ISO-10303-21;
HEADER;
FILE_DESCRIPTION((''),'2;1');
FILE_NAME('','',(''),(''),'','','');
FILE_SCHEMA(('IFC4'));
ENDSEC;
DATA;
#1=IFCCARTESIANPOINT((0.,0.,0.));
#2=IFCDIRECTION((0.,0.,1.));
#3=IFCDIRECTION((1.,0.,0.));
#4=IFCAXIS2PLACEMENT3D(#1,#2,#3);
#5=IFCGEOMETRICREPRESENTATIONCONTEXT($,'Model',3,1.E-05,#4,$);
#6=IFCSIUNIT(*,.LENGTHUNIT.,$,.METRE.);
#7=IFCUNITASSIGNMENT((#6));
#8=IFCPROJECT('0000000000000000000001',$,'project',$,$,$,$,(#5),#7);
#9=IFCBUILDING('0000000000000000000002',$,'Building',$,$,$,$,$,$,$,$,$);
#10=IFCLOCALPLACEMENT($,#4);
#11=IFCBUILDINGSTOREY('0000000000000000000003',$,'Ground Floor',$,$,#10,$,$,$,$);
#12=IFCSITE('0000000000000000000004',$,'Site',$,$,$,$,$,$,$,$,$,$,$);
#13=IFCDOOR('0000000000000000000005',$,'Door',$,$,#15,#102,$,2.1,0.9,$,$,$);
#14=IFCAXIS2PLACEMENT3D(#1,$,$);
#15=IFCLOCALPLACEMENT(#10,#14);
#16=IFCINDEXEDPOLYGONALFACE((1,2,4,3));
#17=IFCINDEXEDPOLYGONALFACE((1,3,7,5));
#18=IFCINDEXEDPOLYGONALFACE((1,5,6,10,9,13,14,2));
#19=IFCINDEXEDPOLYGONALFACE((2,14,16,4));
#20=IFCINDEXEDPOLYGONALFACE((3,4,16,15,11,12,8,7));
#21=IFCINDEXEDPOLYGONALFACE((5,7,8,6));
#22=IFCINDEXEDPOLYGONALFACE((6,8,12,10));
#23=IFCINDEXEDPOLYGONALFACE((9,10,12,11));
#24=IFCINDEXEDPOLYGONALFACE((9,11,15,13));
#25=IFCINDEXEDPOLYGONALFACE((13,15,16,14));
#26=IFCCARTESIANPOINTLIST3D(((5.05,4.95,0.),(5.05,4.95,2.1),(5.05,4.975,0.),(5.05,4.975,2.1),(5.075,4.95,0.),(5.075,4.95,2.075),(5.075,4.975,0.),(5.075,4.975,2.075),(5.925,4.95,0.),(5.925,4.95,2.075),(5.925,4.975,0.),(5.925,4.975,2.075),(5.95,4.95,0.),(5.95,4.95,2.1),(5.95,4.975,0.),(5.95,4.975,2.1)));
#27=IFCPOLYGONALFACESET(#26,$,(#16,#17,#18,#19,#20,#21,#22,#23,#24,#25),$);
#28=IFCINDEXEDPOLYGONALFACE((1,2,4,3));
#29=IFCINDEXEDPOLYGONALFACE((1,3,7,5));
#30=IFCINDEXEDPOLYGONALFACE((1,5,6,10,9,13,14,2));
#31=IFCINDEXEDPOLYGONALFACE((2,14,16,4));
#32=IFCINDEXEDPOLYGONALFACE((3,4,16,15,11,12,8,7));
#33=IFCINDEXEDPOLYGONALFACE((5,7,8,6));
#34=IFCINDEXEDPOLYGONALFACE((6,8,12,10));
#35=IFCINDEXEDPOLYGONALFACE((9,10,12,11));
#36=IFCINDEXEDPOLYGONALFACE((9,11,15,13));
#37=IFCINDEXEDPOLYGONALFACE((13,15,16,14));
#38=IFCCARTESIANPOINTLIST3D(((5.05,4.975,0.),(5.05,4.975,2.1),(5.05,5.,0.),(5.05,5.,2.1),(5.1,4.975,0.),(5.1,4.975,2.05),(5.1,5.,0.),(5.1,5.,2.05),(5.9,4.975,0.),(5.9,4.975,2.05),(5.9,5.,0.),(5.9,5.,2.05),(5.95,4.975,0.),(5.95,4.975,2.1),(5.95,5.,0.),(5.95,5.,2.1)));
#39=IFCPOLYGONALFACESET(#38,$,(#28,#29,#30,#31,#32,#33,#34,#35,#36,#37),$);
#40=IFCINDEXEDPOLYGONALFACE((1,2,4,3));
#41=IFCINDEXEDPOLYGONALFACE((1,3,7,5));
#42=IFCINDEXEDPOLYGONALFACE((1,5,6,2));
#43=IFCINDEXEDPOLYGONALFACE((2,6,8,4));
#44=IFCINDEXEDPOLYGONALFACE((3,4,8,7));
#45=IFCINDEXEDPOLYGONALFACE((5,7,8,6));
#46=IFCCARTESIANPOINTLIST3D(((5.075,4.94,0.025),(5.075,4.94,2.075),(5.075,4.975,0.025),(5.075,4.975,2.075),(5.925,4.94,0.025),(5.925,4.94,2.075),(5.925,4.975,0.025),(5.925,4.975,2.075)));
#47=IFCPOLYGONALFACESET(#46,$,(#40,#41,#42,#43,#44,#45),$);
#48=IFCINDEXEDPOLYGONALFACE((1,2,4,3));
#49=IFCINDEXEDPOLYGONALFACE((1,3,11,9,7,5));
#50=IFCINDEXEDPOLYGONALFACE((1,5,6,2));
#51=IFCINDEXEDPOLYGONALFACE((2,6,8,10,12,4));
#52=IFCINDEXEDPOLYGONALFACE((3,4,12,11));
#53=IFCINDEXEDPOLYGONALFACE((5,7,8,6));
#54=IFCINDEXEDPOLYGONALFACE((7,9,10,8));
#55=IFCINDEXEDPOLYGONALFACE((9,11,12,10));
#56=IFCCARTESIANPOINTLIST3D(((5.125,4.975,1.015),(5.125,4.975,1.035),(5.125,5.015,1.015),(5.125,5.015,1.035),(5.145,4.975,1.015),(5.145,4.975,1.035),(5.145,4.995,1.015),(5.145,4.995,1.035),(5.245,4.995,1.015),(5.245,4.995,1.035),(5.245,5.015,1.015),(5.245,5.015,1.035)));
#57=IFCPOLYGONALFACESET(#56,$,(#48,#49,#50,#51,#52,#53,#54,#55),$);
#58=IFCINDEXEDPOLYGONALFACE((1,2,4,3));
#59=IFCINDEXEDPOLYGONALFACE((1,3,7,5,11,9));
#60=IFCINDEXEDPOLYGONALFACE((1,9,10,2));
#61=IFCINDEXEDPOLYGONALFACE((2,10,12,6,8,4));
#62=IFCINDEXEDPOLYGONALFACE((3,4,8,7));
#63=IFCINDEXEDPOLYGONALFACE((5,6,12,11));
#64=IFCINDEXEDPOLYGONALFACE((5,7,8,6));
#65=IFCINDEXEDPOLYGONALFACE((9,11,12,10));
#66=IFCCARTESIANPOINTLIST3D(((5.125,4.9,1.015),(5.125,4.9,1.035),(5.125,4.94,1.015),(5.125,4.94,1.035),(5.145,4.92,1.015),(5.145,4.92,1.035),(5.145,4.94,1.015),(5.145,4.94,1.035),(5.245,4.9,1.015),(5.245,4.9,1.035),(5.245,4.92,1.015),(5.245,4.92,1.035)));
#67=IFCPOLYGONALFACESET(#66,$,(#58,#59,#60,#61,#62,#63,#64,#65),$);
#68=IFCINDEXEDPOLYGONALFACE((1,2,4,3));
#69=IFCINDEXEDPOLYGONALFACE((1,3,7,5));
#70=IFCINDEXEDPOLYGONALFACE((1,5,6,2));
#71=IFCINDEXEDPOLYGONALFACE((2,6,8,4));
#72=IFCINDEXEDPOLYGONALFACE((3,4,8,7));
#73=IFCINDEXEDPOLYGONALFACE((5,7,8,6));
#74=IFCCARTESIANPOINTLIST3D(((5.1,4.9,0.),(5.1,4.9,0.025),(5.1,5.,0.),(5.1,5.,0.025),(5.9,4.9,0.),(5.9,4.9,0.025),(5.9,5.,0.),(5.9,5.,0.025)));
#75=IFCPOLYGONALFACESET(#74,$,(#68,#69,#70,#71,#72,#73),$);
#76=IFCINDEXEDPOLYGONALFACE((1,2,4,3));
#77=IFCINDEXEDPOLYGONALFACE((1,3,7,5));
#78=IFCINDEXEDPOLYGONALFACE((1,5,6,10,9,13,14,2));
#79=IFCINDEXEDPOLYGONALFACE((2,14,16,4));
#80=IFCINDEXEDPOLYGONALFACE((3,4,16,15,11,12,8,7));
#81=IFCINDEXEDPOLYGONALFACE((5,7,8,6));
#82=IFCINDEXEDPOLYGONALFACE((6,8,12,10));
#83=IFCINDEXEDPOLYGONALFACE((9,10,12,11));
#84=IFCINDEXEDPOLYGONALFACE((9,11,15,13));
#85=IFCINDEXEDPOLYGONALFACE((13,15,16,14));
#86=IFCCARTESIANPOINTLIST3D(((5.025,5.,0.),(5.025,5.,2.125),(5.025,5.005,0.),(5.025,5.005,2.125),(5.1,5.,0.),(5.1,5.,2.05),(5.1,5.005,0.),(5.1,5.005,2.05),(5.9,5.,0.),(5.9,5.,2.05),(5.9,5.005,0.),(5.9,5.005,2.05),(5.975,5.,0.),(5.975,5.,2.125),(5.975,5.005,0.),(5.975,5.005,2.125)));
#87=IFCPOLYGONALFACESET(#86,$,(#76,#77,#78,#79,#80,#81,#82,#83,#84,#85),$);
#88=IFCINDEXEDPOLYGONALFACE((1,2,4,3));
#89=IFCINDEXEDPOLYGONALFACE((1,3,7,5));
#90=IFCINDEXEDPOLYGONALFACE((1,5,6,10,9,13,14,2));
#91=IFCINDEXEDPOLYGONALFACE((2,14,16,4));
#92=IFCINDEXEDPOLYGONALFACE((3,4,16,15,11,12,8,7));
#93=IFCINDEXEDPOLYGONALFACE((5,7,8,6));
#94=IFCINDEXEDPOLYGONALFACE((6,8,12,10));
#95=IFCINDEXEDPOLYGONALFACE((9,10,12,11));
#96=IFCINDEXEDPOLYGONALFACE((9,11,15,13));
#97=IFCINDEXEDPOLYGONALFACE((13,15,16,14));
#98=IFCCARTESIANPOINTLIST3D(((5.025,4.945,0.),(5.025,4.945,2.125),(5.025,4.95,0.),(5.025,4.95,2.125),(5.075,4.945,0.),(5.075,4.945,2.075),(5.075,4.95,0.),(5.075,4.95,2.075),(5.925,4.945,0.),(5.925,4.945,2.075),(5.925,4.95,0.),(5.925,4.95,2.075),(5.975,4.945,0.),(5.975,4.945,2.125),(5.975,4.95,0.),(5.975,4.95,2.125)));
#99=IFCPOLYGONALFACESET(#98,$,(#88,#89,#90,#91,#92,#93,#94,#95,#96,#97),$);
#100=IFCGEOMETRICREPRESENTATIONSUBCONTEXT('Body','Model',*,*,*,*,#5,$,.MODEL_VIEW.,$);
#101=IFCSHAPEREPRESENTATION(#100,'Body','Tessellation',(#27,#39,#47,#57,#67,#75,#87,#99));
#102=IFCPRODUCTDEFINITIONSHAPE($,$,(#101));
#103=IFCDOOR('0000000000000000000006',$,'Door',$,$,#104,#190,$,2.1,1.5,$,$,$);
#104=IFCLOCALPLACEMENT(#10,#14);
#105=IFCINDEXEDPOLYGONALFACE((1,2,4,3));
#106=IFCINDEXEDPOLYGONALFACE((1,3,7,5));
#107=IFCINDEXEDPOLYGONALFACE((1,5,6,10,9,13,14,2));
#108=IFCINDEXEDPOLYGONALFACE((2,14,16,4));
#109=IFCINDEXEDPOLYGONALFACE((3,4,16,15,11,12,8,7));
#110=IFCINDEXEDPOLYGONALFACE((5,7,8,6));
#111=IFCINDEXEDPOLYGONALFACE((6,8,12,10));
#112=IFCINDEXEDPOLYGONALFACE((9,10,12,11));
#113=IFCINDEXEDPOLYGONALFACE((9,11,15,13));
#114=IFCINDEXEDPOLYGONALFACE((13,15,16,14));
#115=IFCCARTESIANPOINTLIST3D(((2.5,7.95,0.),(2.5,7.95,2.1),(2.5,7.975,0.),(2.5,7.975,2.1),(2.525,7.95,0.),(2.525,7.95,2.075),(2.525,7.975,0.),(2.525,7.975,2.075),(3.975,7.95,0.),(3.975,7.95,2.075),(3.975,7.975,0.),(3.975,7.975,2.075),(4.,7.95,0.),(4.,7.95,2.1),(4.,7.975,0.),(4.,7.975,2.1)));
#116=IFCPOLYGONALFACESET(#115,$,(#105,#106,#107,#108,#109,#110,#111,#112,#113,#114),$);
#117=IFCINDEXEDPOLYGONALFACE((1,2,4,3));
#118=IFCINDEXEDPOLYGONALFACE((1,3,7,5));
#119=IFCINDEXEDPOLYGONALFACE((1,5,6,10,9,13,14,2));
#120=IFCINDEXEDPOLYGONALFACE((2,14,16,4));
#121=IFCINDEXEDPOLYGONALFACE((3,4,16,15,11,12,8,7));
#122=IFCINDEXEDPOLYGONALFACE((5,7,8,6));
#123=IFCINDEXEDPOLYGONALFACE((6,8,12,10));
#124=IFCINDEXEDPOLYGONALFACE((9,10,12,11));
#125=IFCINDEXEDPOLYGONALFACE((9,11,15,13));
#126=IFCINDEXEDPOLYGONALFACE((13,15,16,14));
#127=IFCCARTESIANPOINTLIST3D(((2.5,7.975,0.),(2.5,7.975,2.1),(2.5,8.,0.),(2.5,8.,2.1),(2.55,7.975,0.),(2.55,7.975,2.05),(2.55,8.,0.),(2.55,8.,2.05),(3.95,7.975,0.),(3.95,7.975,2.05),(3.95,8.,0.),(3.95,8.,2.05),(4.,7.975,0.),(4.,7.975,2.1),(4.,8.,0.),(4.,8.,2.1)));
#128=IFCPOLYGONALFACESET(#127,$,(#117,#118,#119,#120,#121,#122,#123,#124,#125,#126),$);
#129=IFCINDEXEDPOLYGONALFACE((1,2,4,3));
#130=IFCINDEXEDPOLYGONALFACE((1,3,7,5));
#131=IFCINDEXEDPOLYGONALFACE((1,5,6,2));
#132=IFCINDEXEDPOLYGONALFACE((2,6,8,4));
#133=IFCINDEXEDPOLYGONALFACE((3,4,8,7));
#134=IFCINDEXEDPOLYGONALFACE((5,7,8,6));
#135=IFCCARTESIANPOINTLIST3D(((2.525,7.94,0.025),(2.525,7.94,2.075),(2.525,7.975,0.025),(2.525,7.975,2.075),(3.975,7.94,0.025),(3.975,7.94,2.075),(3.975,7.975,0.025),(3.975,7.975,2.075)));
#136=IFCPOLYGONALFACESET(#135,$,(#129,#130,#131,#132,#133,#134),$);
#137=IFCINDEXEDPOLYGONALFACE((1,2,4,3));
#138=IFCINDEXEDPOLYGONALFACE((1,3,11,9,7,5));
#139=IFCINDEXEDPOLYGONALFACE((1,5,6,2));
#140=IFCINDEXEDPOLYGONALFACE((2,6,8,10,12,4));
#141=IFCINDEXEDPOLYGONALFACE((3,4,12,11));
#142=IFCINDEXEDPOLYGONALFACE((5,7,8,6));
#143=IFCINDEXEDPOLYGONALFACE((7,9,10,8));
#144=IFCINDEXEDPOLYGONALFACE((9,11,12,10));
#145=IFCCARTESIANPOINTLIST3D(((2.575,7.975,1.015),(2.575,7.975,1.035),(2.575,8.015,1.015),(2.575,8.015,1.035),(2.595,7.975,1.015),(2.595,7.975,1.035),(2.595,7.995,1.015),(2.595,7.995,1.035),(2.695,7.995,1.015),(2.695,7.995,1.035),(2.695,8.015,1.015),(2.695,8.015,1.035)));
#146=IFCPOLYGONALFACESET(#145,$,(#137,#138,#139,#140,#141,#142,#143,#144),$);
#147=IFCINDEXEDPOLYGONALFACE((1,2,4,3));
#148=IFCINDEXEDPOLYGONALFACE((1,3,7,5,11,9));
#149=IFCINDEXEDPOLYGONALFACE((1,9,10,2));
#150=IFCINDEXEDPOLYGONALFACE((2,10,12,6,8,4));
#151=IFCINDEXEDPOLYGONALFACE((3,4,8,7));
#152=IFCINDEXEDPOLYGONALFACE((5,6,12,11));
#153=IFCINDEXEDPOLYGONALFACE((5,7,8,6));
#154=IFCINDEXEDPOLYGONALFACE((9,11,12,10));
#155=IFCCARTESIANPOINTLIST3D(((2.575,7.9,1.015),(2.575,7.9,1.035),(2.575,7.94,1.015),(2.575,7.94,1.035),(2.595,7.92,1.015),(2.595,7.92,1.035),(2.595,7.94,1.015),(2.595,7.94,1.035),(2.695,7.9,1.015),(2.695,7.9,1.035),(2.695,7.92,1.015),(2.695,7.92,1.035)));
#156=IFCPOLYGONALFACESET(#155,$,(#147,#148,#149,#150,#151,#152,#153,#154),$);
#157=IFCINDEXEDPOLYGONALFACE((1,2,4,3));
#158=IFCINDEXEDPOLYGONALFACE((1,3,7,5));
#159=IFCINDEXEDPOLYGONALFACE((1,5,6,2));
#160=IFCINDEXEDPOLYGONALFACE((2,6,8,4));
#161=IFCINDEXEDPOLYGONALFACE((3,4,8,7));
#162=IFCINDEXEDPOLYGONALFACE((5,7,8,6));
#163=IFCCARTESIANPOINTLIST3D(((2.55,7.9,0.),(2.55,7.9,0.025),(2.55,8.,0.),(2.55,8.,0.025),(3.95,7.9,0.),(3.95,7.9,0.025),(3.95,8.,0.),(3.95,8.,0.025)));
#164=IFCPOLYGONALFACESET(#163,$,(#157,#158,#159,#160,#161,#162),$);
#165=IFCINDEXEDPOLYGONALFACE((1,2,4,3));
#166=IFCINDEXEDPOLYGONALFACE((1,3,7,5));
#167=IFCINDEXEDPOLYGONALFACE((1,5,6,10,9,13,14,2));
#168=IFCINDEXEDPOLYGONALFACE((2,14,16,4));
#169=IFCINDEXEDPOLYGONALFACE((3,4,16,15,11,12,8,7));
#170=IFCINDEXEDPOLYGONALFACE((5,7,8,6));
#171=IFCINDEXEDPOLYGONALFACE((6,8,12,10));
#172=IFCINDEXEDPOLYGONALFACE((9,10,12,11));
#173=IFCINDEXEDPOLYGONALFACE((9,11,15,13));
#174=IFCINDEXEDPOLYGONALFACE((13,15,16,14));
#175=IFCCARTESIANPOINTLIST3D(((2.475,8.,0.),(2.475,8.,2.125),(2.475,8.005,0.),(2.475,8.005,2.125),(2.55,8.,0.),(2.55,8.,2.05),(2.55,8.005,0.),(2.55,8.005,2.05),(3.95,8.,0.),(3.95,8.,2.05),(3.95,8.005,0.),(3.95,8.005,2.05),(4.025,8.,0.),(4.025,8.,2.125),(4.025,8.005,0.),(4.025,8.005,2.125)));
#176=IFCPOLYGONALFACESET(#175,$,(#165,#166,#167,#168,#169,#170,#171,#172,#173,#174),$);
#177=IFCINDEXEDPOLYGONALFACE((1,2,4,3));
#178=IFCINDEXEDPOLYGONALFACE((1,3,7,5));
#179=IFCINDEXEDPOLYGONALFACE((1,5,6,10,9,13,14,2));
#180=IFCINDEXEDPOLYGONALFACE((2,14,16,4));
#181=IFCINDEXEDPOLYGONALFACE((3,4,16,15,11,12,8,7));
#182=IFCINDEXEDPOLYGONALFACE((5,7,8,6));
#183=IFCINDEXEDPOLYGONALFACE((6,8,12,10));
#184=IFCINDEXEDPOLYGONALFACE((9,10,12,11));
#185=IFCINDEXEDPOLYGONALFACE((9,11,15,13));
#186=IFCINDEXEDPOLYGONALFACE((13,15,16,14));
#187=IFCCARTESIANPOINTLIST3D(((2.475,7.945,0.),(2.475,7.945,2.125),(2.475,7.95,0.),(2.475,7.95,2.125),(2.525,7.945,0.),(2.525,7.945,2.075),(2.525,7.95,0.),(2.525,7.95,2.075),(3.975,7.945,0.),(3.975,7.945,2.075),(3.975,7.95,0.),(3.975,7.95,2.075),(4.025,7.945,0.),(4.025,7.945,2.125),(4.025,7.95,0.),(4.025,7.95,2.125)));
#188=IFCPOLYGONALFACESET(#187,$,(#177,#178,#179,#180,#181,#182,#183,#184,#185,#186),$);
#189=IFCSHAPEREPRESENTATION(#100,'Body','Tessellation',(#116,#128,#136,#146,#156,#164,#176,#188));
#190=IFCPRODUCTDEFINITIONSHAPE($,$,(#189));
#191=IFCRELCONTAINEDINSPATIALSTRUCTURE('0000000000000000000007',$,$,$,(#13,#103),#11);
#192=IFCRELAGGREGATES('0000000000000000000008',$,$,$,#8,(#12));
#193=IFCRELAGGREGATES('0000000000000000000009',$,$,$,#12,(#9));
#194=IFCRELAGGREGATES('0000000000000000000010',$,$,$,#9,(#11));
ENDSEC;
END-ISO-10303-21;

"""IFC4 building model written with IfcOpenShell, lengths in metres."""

from ifc_helpers import new_model, si_unit, frame, origin_with_axes, place, context, subcontext, project, spatial, line, indexed_curve, outline, extrude, element, save


model = new_model("IFC4")

# Units and contexts
model_context = context("Model", 3, precision=1e-05, world=origin_with_axes())
body_context = subcontext(model_context, "Body", "Model", "MODEL_VIEW")
ifc_project = project(units=[si_unit("LENGTHUNIT", "METRE")], contexts=[model_context])

# Site, building, storey
site = spatial("IfcSite", under=ifc_project, Name="Site")
building = spatial("IfcBuilding", under=site, Name="Building")
storey_placement = place(None, origin_with_axes())
storey = spatial("IfcBuildingStorey", under=building, at=storey_placement, Name="Ground Floor")

# Doors
door_1_placement = place(storey_placement, frame((5.95, 5.0, 0.0), z_axis=(0.0, 0.0, 1.0), x_axis=(-1.0, 0.0, 0.0)))
element("IfcDoor", 1, at=door_1_placement, inside=storey, Name="Door", OverallHeight=2.1, OverallWidth=0.9, context=body_context, shape_type="SweptSolid", body=[
    extrude(outline(indexed_curve([(0.0, 0.0), (0.0, 2.1), (0.9, 2.1), (0.9, 0.0), (0.875, 0.0), (0.875, 2.075), (0.025, 2.075), (0.025, 0.0)], segments=[line(1, 2, 3, 4, 5, 6, 7, 8, 1)])), frame((0.0, 0.025, 0.0), z_axis=(0.0, -1.0, 0.0), x_axis=(1.0, 0.0, 0.0)), (0.0, 0.0, -1.0), 0.025),
    extrude(outline(indexed_curve([(0.0, 0.0), (0.0, 2.1), (0.9, 2.1), (0.9, 0.0), (0.85, 0.0), (0.85, 2.05), (0.05, 2.05), (0.05, 0.0)], segments=[line(1, 2, 3, 4, 5, 6, 7, 8, 1)])), frame((0.0, 0.0, 0.0), z_axis=(0.0, -1.0, 0.0), x_axis=(1.0, 0.0, 0.0)), (0.0, 0.0, -1.0), 0.025),
    extrude(outline(indexed_curve([(0.0, 0.0), (0.85, 0.0), (0.85, 0.035), (0.0, 0.035)], segments=[line(1, 2, 3, 4, 1)])), frame((0.025, 0.025, 0.025), z_axis=(0.0, 0.0, 1.0), x_axis=(1.0, 0.0, 0.0)), (0.0, 0.0, 1.0), 2.05),
    extrude(outline(indexed_curve([(0.0, 0.0), (0.0, -0.04), (-0.12, -0.04), (-0.12, -0.02), (-0.02, -0.02), (-0.02, 0.0)], segments=[line(1, 2, 3, 4, 5, 6, 1)])), frame((0.825, 0.025, 1.015), z_axis=(0.0, 0.0, 1.0), x_axis=(1.0, 0.0, 0.0)), (0.0, 0.0, 1.0), 0.02),
    extrude(outline(indexed_curve([(0.0, 0.0), (0.0, 0.04), (-0.12, 0.04), (-0.12, 0.02), (-0.02, 0.02), (-0.02, 0.0)], segments=[line(1, 2, 3, 4, 5, 6, 1)])), frame((0.825, 0.06, 1.015), z_axis=(0.0, 0.0, 1.0), x_axis=(1.0, 0.0, 0.0)), (0.0, 0.0, 1.0), 0.02),
    extrude(outline(indexed_curve([(0.0, 0.0), (0.8, 0.0), (0.8, 0.1), (0.0, 0.1)], segments=[line(1, 2, 3, 4, 1)])), frame((0.05, 0.0, 0.0), z_axis=(0.0, 0.0, 1.0), x_axis=(1.0, 0.0, 0.0)), (0.0, 0.0, 1.0), 0.025),
    extrude(outline(indexed_curve([(0.0, 0.0), (0.0, 2.125), (0.95, 2.125), (0.95, 0.0), (0.875, 0.0), (0.875, 2.05), (0.075, 2.05), (0.075, 0.0)], segments=[line(1, 2, 3, 4, 5, 6, 7, 8, 1)])), frame((-0.025, -0.005, 0.0), z_axis=(0.0, -1.0, 0.0), x_axis=(1.0, 0.0, 0.0)), (0.0, 0.0, -1.0), 0.005),
    extrude(outline(indexed_curve([(0.0, 0.0), (0.0, 2.125), (0.95, 2.125), (0.95, 0.0), (0.9, 0.0), (0.9, 2.075), (0.05, 2.075), (0.05, 0.0)], segments=[line(1, 2, 3, 4, 5, 6, 7, 8, 1)])), frame((-0.025, 0.05, 0.0), z_axis=(0.0, -1.0, 0.0), x_axis=(1.0, 0.0, 0.0)), (0.0, 0.0, -1.0), 0.005),
])
door_2_placement = place(storey_placement, frame((4.0, 8.0, 0.0), z_axis=(0.0, 0.0, 1.0), x_axis=(-1.0, 0.0, 0.0)))
element("IfcDoor", 2, at=door_2_placement, inside=storey, Name="Door", OverallHeight=2.1, OverallWidth=1.5, context=body_context, shape_type="SweptSolid", body=[
    extrude(outline(indexed_curve([(0.0, 0.0), (0.0, 2.1), (1.5, 2.1), (1.5, 0.0), (1.475, 0.0), (1.475, 2.075), (0.025, 2.075), (0.025, 0.0)], segments=[line(1, 2, 3, 4, 5, 6, 7, 8, 1)])), frame((0.0, 0.025, 0.0), z_axis=(0.0, -1.0, 0.0), x_axis=(1.0, 0.0, 0.0)), (0.0, 0.0, -1.0), 0.025),
    extrude(outline(indexed_curve([(0.0, 0.0), (0.0, 2.1), (1.5, 2.1), (1.5, 0.0), (1.45, 0.0), (1.45, 2.05), (0.05, 2.05), (0.05, 0.0)], segments=[line(1, 2, 3, 4, 5, 6, 7, 8, 1)])), frame((0.0, 0.0, 0.0), z_axis=(0.0, -1.0, 0.0), x_axis=(1.0, 0.0, 0.0)), (0.0, 0.0, -1.0), 0.025),
    extrude(outline(indexed_curve([(0.0, 0.0), (1.45, 0.0), (1.45, 0.035), (0.0, 0.035)], segments=[line(1, 2, 3, 4, 1)])), frame((0.025, 0.025, 0.025), z_axis=(0.0, 0.0, 1.0), x_axis=(1.0, 0.0, 0.0)), (0.0, 0.0, 1.0), 2.05),
    extrude(outline(indexed_curve([(0.0, 0.0), (0.0, -0.04), (-0.12, -0.04), (-0.12, -0.02), (-0.02, -0.02), (-0.02, 0.0)], segments=[line(1, 2, 3, 4, 5, 6, 1)])), frame((1.425, 0.025, 1.015), z_axis=(0.0, 0.0, 1.0), x_axis=(1.0, 0.0, 0.0)), (0.0, 0.0, 1.0), 0.02),
    extrude(outline(indexed_curve([(0.0, 0.0), (0.0, 0.04), (-0.12, 0.04), (-0.12, 0.02), (-0.02, 0.02), (-0.02, 0.0)], segments=[line(1, 2, 3, 4, 5, 6, 1)])), frame((1.425, 0.06, 1.015), z_axis=(0.0, 0.0, 1.0), x_axis=(1.0, 0.0, 0.0)), (0.0, 0.0, 1.0), 0.02),
    extrude(outline(indexed_curve([(0.0, 0.0), (1.4, 0.0), (1.4, 0.1), (0.0, 0.1)], segments=[line(1, 2, 3, 4, 1)])), frame((0.05, 0.0, 0.0), z_axis=(0.0, 0.0, 1.0), x_axis=(1.0, 0.0, 0.0)), (0.0, 0.0, 1.0), 0.025),
    extrude(outline(indexed_curve([(0.0, 0.0), (0.0, 2.125), (1.55, 2.125), (1.55, 0.0), (1.475, 0.0), (1.475, 2.05), (0.075, 2.05), (0.075, 0.0)], segments=[line(1, 2, 3, 4, 5, 6, 7, 8, 1)])), frame((-0.025, -0.005, 0.0), z_axis=(0.0, -1.0, 0.0), x_axis=(1.0, 0.0, 0.0)), (0.0, 0.0, -1.0), 0.005),
    extrude(outline(indexed_curve([(0.0, 0.0), (0.0, 2.125), (1.55, 2.125), (1.55, 0.0), (1.5, 0.0), (1.5, 2.075), (0.05, 2.075), (0.05, 0.0)], segments=[line(1, 2, 3, 4, 5, 6, 7, 8, 1)])), frame((-0.025, 0.05, 0.0), z_axis=(0.0, -1.0, 0.0), x_axis=(1.0, 0.0, 0.0)), (0.0, 0.0, -1.0), 0.005),
])

save(model, "model.ifc")
